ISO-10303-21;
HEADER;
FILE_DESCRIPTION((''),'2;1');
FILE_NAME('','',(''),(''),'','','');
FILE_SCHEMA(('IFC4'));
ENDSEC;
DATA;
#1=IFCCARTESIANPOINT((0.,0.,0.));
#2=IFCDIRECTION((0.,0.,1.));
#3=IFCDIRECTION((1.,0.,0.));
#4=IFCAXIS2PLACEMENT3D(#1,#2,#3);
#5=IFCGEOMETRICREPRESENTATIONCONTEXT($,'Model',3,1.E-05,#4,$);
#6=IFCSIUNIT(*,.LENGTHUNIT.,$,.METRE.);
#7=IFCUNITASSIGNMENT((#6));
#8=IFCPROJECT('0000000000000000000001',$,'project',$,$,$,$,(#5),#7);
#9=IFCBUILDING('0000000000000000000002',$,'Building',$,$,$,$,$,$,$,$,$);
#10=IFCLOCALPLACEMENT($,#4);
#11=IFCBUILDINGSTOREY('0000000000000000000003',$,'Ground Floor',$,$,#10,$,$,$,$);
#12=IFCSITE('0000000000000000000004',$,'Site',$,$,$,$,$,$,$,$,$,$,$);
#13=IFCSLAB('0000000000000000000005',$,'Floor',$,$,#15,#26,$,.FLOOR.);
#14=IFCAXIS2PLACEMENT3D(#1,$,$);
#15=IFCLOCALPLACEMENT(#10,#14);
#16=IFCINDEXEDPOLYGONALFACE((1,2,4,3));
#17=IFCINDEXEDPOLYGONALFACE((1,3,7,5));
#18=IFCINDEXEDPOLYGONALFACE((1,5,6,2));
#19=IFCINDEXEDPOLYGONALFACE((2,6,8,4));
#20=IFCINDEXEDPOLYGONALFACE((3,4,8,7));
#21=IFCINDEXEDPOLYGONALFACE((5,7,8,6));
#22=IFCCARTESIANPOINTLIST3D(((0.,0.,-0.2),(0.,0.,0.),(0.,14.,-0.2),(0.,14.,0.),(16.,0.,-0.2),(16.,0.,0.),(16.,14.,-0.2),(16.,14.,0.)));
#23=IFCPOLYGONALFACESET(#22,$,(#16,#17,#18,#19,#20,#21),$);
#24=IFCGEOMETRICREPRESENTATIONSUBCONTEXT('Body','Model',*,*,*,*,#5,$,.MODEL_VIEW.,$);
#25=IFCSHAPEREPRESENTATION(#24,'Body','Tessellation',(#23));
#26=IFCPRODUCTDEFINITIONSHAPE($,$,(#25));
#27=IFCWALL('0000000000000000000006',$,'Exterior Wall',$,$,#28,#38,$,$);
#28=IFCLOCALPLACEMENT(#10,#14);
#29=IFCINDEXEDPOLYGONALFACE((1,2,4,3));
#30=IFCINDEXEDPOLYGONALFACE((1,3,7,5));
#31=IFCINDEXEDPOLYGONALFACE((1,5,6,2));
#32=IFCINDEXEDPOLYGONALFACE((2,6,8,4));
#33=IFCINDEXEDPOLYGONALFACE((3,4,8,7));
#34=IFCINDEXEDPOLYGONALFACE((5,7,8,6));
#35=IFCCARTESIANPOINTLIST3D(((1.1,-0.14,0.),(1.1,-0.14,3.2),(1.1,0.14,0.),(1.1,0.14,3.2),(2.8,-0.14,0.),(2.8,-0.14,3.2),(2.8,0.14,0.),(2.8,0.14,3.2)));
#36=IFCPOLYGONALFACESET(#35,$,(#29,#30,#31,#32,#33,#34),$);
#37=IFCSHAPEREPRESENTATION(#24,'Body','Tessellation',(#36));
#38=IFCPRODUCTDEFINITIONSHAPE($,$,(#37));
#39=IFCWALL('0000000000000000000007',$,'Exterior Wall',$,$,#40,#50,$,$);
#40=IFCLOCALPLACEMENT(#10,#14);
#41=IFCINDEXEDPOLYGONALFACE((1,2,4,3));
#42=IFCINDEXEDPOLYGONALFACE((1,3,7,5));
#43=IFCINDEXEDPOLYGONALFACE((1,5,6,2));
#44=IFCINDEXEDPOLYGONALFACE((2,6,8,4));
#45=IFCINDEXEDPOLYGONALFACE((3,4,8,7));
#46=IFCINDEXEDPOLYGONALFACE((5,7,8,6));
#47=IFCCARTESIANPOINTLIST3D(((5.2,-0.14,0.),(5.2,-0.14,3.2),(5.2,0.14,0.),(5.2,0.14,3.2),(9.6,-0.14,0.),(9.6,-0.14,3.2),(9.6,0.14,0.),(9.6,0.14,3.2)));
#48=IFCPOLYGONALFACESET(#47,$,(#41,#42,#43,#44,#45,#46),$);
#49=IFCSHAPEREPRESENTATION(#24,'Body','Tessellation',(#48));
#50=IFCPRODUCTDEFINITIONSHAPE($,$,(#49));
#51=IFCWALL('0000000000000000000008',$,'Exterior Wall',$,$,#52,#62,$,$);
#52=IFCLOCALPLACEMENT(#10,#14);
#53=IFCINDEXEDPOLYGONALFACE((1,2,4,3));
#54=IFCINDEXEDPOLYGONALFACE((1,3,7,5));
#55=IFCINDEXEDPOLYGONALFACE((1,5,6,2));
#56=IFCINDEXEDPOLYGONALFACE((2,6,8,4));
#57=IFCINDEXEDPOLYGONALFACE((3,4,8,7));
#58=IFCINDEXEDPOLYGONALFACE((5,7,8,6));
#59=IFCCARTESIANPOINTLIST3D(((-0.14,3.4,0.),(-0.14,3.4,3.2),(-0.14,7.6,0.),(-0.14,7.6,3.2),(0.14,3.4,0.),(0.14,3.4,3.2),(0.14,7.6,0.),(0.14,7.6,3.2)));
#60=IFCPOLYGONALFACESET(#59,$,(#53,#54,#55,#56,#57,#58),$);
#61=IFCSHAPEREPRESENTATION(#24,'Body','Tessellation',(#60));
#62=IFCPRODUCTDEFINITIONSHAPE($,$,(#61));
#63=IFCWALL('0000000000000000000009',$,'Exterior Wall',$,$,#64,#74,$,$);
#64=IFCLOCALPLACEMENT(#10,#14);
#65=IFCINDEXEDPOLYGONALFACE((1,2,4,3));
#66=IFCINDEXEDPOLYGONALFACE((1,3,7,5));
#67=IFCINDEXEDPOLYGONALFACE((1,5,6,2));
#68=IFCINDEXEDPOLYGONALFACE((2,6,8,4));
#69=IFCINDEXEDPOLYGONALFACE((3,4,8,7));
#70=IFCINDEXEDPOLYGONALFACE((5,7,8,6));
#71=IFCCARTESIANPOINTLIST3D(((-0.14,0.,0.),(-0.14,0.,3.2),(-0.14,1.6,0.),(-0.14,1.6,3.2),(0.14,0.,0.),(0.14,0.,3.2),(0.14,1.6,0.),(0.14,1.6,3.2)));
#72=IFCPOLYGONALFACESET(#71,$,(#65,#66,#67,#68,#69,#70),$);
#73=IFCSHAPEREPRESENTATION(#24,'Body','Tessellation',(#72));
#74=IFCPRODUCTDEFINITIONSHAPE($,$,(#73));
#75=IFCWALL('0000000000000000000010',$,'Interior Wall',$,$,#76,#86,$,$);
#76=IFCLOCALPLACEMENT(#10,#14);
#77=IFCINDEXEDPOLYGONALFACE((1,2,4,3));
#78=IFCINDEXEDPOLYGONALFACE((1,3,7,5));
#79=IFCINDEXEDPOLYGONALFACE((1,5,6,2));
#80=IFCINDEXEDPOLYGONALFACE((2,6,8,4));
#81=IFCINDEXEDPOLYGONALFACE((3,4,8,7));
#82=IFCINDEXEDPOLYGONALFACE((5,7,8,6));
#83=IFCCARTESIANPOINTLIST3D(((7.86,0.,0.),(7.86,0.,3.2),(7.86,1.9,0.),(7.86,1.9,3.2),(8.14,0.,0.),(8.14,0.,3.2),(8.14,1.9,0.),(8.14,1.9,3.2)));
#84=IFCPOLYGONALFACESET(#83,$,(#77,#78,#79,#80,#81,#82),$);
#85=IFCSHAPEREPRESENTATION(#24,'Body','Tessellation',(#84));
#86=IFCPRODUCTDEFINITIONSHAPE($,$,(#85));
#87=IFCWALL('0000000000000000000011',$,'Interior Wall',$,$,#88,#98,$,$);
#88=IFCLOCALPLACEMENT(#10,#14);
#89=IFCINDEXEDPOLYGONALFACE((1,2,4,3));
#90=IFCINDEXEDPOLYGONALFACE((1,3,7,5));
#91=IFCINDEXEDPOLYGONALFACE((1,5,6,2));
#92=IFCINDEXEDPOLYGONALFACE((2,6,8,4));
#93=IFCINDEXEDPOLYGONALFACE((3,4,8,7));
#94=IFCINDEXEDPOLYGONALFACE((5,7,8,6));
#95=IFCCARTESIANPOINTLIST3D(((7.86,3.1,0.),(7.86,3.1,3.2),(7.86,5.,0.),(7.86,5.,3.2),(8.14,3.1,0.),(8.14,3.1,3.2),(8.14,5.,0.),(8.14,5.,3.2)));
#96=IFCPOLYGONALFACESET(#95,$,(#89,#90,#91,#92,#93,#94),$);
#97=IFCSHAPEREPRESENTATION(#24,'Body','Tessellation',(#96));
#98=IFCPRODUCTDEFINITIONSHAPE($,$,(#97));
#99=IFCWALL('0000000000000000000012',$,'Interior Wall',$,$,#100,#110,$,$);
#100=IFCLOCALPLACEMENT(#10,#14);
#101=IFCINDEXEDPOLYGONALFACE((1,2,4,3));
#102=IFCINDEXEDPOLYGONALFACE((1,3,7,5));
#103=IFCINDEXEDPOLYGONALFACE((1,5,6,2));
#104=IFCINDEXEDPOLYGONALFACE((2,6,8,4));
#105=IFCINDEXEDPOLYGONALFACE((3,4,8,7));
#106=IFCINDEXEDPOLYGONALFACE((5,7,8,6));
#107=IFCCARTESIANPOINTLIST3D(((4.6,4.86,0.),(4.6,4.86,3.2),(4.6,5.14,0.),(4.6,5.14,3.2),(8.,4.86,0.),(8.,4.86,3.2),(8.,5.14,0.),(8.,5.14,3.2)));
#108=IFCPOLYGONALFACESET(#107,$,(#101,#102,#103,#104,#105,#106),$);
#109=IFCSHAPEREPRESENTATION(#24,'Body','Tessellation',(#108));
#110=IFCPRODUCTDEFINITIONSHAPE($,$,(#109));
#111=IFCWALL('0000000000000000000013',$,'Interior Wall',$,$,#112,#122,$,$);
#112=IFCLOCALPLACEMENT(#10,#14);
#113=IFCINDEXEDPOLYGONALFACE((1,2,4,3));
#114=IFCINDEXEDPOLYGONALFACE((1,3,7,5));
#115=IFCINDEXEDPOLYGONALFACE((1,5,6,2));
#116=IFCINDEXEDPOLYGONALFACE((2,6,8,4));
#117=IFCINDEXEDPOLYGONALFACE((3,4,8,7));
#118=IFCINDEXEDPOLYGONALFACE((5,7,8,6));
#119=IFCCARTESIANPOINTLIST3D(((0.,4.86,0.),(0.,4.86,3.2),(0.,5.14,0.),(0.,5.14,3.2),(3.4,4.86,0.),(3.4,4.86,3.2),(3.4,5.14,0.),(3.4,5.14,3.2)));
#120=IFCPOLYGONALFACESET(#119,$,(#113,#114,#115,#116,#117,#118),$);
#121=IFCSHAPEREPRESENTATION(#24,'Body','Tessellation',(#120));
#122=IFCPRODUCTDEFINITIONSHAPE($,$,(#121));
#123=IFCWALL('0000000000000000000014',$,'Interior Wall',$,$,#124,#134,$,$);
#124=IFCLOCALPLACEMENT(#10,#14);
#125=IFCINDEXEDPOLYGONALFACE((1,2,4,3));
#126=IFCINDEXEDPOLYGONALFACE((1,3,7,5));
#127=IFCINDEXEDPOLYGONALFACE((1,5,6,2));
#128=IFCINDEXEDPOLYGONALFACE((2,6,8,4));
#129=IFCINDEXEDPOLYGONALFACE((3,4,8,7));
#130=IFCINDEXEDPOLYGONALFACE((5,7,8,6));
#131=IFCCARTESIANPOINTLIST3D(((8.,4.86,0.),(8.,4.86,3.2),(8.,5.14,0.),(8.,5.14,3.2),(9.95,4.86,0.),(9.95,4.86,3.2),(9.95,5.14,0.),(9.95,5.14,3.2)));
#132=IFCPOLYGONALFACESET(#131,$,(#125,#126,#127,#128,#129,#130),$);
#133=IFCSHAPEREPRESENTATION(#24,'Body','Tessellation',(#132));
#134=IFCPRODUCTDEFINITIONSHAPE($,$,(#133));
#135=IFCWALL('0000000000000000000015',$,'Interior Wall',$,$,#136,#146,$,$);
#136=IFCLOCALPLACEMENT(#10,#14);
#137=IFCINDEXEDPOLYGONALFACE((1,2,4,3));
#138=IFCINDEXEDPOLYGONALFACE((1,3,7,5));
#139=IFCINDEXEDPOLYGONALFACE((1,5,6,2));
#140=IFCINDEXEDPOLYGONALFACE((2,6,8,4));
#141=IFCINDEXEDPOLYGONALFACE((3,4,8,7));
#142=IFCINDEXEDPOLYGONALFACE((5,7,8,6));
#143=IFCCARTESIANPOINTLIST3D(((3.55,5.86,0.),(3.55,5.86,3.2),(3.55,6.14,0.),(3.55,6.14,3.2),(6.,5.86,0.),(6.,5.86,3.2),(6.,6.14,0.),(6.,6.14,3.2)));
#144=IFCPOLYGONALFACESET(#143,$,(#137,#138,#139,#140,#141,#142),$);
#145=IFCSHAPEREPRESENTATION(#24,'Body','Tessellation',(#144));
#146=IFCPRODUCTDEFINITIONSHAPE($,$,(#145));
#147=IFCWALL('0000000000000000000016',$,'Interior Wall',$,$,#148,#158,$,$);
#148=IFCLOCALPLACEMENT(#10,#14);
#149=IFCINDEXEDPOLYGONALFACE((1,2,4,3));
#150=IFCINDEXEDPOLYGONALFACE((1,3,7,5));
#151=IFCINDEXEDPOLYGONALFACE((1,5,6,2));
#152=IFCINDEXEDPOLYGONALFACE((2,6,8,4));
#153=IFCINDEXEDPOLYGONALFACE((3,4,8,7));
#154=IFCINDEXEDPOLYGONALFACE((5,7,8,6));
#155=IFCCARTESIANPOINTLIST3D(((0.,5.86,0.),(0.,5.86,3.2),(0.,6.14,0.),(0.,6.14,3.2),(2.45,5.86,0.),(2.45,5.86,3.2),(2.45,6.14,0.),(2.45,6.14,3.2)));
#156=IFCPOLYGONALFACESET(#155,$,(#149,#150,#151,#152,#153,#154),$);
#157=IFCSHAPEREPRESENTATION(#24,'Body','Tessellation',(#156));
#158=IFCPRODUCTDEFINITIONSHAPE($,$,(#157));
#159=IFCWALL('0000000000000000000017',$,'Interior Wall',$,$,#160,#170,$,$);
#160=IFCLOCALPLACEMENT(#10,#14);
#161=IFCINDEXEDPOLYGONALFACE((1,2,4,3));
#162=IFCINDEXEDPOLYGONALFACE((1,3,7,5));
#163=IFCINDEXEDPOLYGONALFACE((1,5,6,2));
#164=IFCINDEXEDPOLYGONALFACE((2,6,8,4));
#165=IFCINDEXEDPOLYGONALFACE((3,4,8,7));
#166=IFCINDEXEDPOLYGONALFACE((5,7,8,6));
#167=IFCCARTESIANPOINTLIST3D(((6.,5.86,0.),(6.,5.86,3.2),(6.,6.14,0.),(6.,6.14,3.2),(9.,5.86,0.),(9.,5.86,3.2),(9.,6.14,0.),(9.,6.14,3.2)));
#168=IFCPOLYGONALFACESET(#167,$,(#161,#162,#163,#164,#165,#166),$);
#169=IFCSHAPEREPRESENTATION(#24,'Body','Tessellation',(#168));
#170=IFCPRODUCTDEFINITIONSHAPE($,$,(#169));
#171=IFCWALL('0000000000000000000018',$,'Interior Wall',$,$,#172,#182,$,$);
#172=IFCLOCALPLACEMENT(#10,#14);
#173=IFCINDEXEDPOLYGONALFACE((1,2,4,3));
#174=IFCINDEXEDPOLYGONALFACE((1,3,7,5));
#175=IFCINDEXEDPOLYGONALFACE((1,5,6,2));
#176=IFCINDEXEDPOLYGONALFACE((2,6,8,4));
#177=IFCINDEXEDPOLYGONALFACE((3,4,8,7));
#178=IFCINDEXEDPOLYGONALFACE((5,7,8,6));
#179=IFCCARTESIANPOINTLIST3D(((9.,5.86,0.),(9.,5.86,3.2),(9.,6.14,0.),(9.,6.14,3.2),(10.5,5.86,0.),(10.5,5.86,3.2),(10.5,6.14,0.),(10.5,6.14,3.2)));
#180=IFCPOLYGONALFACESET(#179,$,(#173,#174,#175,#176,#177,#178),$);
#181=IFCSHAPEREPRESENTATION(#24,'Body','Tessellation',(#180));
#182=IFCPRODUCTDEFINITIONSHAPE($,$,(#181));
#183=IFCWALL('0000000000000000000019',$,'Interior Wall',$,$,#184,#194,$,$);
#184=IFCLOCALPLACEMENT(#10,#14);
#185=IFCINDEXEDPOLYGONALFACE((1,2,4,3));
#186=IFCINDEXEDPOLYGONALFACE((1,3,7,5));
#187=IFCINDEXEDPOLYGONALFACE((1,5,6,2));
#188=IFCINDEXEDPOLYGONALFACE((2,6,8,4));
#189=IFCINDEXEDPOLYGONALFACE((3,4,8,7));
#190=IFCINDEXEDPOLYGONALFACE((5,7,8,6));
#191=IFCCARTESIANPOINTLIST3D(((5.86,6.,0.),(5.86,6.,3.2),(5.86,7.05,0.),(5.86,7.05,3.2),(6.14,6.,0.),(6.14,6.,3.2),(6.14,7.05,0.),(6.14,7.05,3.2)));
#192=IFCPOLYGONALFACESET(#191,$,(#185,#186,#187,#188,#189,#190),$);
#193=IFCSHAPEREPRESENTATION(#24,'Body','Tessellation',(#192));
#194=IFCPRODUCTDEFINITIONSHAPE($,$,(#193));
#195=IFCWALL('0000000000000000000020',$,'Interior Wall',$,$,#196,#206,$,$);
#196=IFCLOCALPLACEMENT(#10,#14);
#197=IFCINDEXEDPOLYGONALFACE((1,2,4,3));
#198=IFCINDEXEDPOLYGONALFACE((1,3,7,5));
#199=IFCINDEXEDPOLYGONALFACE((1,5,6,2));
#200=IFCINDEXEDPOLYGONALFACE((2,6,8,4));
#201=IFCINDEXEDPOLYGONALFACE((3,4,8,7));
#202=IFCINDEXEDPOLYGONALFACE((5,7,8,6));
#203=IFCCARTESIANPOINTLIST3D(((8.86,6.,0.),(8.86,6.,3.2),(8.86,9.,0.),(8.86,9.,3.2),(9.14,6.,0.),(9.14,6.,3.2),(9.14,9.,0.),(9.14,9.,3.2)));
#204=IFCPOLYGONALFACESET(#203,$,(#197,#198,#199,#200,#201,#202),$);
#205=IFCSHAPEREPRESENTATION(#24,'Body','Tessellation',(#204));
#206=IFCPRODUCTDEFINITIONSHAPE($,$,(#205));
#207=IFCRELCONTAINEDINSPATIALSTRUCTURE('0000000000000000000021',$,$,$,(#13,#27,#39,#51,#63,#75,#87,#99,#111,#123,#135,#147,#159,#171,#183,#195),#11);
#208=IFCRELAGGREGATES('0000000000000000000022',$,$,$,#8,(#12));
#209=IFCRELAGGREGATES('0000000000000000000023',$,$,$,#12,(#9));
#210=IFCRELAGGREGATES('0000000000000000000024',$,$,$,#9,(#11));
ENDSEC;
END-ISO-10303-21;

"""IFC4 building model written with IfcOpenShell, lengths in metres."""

from ifc_helpers import new_model, si_unit, frame, origin_with_axes, place, context, subcontext, project, spatial, indexed_curve, outline, extrude, element, save


model = new_model("IFC4")

# Units and contexts
model_context = context("Model", 3, precision=1e-05, world=origin_with_axes())
body_context = subcontext(model_context, "Body", "Model", "MODEL_VIEW")
ifc_project = project(units=[si_unit("LENGTHUNIT", "METRE")], contexts=[model_context])

# Site, building, storey
site = spatial("IfcSite", under=ifc_project, Name="Site")
building = spatial("IfcBuilding", under=site, Name="Building")
storey_placement = place(None, origin_with_axes())
storey = spatial("IfcBuildingStorey", under=building, at=storey_placement, Name="Ground Floor")

# Slab
slab_placement = place(storey_placement, frame((0.0, 0.0, -0.2), z_axis=(0.0, 0.0, 1.0), x_axis=(1.0, 0.0, 0.0)))
element("IfcSlab", 1, at=slab_placement, inside=storey, Name="Floor", PredefinedType="FLOOR", context=body_context, shape_type="SweptSolid", body=[
    extrude(outline(indexed_curve([(0.0, 0.0), (16.0, 0.0), (16.0, 14.0), (0.0, 14.0)])), None, (0.0, 0.0, 1.0), 0.2),
])

# Walls
wall_1_placement = place(storey_placement, frame((1.1, 0.0, 0.0), z_axis=(0.0, 0.0, 1.0), x_axis=(1.0, 0.0, 0.0)))
element("IfcWall", 2, at=wall_1_placement, inside=storey, Name="Exterior Wall", context=body_context, shape_type="SweptSolid", body=[
    extrude(outline(indexed_curve([(0.0, 0.0), (0.0, 0.28), (1.7, 0.28), (1.7, 0.0), (0.0, 0.0)], self_intersect=False)), frame((0.0, -0.14, 0.0), z_axis=(0.0, 0.0, 1.0), x_axis=(1.0, 0.0, 0.0)), (0.0, 0.0, 1.0), 3.2),
])
wall_2_placement = place(storey_placement, frame((5.2, 0.0, 0.0), z_axis=(0.0, 0.0, 1.0), x_axis=(1.0, 0.0, 0.0)))
element("IfcWall", 3, at=wall_2_placement, inside=storey, Name="Exterior Wall", context=body_context, shape_type="SweptSolid", body=[
    extrude(outline(indexed_curve([(0.0, 0.0), (0.0, 0.28), (4.4, 0.28), (4.4, 0.0), (0.0, 0.0)], self_intersect=False)), frame((0.0, -0.14, 0.0), z_axis=(0.0, 0.0, 1.0), x_axis=(1.0, 0.0, 0.0)), (0.0, 0.0, 1.0), 3.2),
])
wall_3_placement = place(storey_placement, frame((0.0, 7.6, 0.0), z_axis=(0.0, 0.0, 1.0), x_axis=(0.0, -1.0, 0.0)))
element("IfcWall", 4, at=wall_3_placement, inside=storey, Name="Exterior Wall", context=body_context, shape_type="SweptSolid", body=[
    extrude(outline(indexed_curve([(0.0, 0.0), (0.0, 0.28), (4.2, 0.28), (4.2, 0.0), (0.0, 0.0)], self_intersect=False)), frame((0.0, -0.14, 0.0), z_axis=(0.0, 0.0, 1.0), x_axis=(1.0, 0.0, 0.0)), (0.0, 0.0, 1.0), 3.2),
])
wall_4_placement = place(storey_placement, frame((0.0, 1.6, 0.0), z_axis=(0.0, 0.0, 1.0), x_axis=(0.0, -1.0, 0.0)))
element("IfcWall", 5, at=wall_4_placement, inside=storey, Name="Exterior Wall", context=body_context, shape_type="SweptSolid", body=[
    extrude(outline(indexed_curve([(0.0, 0.0), (0.0, 0.28), (1.6, 0.28), (1.6, 0.0), (0.0, 0.0)], self_intersect=False)), frame((0.0, -0.14, 0.0), z_axis=(0.0, 0.0, 1.0), x_axis=(1.0, 0.0, 0.0)), (0.0, 0.0, 1.0), 3.2),
])
for number, where, z_axis, x_axis, name in (
    (6, (8.0, 0.0, 0.0), (0.0, 0.0, 1.0), (0.0, 1.0, 0.0), "Interior Wall"),
    (7, (8.0, 3.1, 0.0), (0.0, 0.0, 1.0), (0.0, 1.0, 0.0), "Interior Wall"),
):
    element("IfcWall", number, at=place(storey_placement, frame(where, z_axis=z_axis, x_axis=x_axis)), inside=storey, Name=name, context=body_context, shape_type="SweptSolid", body=[
        extrude(outline(indexed_curve([(0.0, 0.0), (0.0, 0.28), (1.9, 0.28), (1.9, 0.0), (0.0, 0.0)], self_intersect=False)), frame((0.0, -0.14, 0.0), z_axis=(0.0, 0.0, 1.0), x_axis=(1.0, 0.0, 0.0)), (0.0, 0.0, 1.0), 3.2),
    ])
for number, where, z_axis, x_axis, name in (
    (8, (8.0, 5.0, 0.0), (0.0, 0.0, 1.0), (-1.0, 0.0, 0.0), "Interior Wall"),
    (9, (3.4, 5.0, 0.0), (0.0, 0.0, 1.0), (-1.0, 0.0, 0.0), "Interior Wall"),
):
    element("IfcWall", number, at=place(storey_placement, frame(where, z_axis=z_axis, x_axis=x_axis)), inside=storey, Name=name, context=body_context, shape_type="SweptSolid", body=[
        extrude(outline(indexed_curve([(0.0, 0.0), (0.0, 0.28), (3.4, 0.28), (3.4, 0.0), (0.0, 0.0)], self_intersect=False)), frame((0.0, -0.14, 0.0), z_axis=(0.0, 0.0, 1.0), x_axis=(1.0, 0.0, 0.0)), (0.0, 0.0, 1.0), 3.2),
    ])
wall_5_placement = place(storey_placement, frame((9.95, 5.0, 0.0), z_axis=(0.0, 0.0, 1.0), x_axis=(-1.0, 0.0, 0.0)))
element("IfcWall", 10, at=wall_5_placement, inside=storey, Name="Interior Wall", context=body_context, shape_type="SweptSolid", body=[
    extrude(outline(indexed_curve([(0.0, 0.0), (0.0, 0.28), (1.95, 0.28), (1.95, 0.0), (0.0, 0.0)], self_intersect=False)), frame((0.0, -0.14, 0.0), z_axis=(0.0, 0.0, 1.0), x_axis=(1.0, 0.0, 0.0)), (0.0, 0.0, 1.0), 3.2),
])
for number, where, z_axis, x_axis, name in (
    (11, (6.0, 6.0, 0.0), (0.0, 0.0, 1.0), (-1.0, 0.0, 0.0), "Interior Wall"),
    (12, (2.45, 6.0, 0.0), (0.0, 0.0, 1.0), (-1.0, 0.0, 0.0), "Interior Wall"),
):
    element("IfcWall", number, at=place(storey_placement, frame(where, z_axis=z_axis, x_axis=x_axis)), inside=storey, Name=name, context=body_context, shape_type="SweptSolid", body=[
        extrude(outline(indexed_curve([(0.0, 0.0), (0.0, 0.28), (2.45, 0.28), (2.45, 0.0), (0.0, 0.0)], self_intersect=False)), frame((0.0, -0.14, 0.0), z_axis=(0.0, 0.0, 1.0), x_axis=(1.0, 0.0, 0.0)), (0.0, 0.0, 1.0), 3.2),
    ])
wall_6_placement = place(storey_placement, frame((9.0, 6.0, 0.0), z_axis=(0.0, 0.0, 1.0), x_axis=(-1.0, 0.0, 0.0)))
element("IfcWall", 13, at=wall_6_placement, inside=storey, Name="Interior Wall", context=body_context, shape_type="SweptSolid", body=[
    extrude(outline(indexed_curve([(0.0, 0.0), (0.0, 0.28), (3.0, 0.28), (3.0, 0.0), (0.0, 0.0)], self_intersect=False)), frame((0.0, -0.14, 0.0), z_axis=(0.0, 0.0, 1.0), x_axis=(1.0, 0.0, 0.0)), (0.0, 0.0, 1.0), 3.2),
])
wall_7_placement = place(storey_placement, frame((10.5, 6.0, 0.0), z_axis=(0.0, 0.0, 1.0), x_axis=(-1.0, 0.0, 0.0)))
element("IfcWall", 14, at=wall_7_placement, inside=storey, Name="Interior Wall", context=body_context, shape_type="SweptSolid", body=[
    extrude(outline(indexed_curve([(0.0, 0.0), (0.0, 0.28), (1.5, 0.28), (1.5, 0.0), (0.0, 0.0)], self_intersect=False)), frame((0.0, -0.14, 0.0), z_axis=(0.0, 0.0, 1.0), x_axis=(1.0, 0.0, 0.0)), (0.0, 0.0, 1.0), 3.2),
])
wall_8_placement = place(storey_placement, frame((6.0, 6.0, 0.0), z_axis=(0.0, 0.0, 1.0), x_axis=(0.0, 1.0, 0.0)))
element("IfcWall", 15, at=wall_8_placement, inside=storey, Name="Interior Wall", context=body_context, shape_type="SweptSolid", body=[
    extrude(outline(indexed_curve([(0.0, 0.0), (0.0, 0.28), (1.05, 0.28), (1.05, 0.0), (0.0, 0.0)], self_intersect=False)), frame((0.0, -0.14, 0.0), z_axis=(0.0, 0.0, 1.0), x_axis=(1.0, 0.0, 0.0)), (0.0, 0.0, 1.0), 3.2),
])
wall_9_placement = place(storey_placement, frame((9.0, 6.0, 0.0), z_axis=(0.0, 0.0, 1.0), x_axis=(0.0, 1.0, 0.0)))
element("IfcWall", 16, at=wall_9_placement, inside=storey, Name="Interior Wall", context=body_context, shape_type="SweptSolid", body=[
    extrude(outline(indexed_curve([(0.0, 0.0), (0.0, 0.28), (3.0, 0.28), (3.0, 0.0), (0.0, 0.0)], self_intersect=False)), frame((0.0, -0.14, 0.0), z_axis=(0.0, 0.0, 1.0), x_axis=(1.0, 0.0, 0.0)), (0.0, 0.0, 1.0), 3.2),
])

save(model, "model.ifc")
